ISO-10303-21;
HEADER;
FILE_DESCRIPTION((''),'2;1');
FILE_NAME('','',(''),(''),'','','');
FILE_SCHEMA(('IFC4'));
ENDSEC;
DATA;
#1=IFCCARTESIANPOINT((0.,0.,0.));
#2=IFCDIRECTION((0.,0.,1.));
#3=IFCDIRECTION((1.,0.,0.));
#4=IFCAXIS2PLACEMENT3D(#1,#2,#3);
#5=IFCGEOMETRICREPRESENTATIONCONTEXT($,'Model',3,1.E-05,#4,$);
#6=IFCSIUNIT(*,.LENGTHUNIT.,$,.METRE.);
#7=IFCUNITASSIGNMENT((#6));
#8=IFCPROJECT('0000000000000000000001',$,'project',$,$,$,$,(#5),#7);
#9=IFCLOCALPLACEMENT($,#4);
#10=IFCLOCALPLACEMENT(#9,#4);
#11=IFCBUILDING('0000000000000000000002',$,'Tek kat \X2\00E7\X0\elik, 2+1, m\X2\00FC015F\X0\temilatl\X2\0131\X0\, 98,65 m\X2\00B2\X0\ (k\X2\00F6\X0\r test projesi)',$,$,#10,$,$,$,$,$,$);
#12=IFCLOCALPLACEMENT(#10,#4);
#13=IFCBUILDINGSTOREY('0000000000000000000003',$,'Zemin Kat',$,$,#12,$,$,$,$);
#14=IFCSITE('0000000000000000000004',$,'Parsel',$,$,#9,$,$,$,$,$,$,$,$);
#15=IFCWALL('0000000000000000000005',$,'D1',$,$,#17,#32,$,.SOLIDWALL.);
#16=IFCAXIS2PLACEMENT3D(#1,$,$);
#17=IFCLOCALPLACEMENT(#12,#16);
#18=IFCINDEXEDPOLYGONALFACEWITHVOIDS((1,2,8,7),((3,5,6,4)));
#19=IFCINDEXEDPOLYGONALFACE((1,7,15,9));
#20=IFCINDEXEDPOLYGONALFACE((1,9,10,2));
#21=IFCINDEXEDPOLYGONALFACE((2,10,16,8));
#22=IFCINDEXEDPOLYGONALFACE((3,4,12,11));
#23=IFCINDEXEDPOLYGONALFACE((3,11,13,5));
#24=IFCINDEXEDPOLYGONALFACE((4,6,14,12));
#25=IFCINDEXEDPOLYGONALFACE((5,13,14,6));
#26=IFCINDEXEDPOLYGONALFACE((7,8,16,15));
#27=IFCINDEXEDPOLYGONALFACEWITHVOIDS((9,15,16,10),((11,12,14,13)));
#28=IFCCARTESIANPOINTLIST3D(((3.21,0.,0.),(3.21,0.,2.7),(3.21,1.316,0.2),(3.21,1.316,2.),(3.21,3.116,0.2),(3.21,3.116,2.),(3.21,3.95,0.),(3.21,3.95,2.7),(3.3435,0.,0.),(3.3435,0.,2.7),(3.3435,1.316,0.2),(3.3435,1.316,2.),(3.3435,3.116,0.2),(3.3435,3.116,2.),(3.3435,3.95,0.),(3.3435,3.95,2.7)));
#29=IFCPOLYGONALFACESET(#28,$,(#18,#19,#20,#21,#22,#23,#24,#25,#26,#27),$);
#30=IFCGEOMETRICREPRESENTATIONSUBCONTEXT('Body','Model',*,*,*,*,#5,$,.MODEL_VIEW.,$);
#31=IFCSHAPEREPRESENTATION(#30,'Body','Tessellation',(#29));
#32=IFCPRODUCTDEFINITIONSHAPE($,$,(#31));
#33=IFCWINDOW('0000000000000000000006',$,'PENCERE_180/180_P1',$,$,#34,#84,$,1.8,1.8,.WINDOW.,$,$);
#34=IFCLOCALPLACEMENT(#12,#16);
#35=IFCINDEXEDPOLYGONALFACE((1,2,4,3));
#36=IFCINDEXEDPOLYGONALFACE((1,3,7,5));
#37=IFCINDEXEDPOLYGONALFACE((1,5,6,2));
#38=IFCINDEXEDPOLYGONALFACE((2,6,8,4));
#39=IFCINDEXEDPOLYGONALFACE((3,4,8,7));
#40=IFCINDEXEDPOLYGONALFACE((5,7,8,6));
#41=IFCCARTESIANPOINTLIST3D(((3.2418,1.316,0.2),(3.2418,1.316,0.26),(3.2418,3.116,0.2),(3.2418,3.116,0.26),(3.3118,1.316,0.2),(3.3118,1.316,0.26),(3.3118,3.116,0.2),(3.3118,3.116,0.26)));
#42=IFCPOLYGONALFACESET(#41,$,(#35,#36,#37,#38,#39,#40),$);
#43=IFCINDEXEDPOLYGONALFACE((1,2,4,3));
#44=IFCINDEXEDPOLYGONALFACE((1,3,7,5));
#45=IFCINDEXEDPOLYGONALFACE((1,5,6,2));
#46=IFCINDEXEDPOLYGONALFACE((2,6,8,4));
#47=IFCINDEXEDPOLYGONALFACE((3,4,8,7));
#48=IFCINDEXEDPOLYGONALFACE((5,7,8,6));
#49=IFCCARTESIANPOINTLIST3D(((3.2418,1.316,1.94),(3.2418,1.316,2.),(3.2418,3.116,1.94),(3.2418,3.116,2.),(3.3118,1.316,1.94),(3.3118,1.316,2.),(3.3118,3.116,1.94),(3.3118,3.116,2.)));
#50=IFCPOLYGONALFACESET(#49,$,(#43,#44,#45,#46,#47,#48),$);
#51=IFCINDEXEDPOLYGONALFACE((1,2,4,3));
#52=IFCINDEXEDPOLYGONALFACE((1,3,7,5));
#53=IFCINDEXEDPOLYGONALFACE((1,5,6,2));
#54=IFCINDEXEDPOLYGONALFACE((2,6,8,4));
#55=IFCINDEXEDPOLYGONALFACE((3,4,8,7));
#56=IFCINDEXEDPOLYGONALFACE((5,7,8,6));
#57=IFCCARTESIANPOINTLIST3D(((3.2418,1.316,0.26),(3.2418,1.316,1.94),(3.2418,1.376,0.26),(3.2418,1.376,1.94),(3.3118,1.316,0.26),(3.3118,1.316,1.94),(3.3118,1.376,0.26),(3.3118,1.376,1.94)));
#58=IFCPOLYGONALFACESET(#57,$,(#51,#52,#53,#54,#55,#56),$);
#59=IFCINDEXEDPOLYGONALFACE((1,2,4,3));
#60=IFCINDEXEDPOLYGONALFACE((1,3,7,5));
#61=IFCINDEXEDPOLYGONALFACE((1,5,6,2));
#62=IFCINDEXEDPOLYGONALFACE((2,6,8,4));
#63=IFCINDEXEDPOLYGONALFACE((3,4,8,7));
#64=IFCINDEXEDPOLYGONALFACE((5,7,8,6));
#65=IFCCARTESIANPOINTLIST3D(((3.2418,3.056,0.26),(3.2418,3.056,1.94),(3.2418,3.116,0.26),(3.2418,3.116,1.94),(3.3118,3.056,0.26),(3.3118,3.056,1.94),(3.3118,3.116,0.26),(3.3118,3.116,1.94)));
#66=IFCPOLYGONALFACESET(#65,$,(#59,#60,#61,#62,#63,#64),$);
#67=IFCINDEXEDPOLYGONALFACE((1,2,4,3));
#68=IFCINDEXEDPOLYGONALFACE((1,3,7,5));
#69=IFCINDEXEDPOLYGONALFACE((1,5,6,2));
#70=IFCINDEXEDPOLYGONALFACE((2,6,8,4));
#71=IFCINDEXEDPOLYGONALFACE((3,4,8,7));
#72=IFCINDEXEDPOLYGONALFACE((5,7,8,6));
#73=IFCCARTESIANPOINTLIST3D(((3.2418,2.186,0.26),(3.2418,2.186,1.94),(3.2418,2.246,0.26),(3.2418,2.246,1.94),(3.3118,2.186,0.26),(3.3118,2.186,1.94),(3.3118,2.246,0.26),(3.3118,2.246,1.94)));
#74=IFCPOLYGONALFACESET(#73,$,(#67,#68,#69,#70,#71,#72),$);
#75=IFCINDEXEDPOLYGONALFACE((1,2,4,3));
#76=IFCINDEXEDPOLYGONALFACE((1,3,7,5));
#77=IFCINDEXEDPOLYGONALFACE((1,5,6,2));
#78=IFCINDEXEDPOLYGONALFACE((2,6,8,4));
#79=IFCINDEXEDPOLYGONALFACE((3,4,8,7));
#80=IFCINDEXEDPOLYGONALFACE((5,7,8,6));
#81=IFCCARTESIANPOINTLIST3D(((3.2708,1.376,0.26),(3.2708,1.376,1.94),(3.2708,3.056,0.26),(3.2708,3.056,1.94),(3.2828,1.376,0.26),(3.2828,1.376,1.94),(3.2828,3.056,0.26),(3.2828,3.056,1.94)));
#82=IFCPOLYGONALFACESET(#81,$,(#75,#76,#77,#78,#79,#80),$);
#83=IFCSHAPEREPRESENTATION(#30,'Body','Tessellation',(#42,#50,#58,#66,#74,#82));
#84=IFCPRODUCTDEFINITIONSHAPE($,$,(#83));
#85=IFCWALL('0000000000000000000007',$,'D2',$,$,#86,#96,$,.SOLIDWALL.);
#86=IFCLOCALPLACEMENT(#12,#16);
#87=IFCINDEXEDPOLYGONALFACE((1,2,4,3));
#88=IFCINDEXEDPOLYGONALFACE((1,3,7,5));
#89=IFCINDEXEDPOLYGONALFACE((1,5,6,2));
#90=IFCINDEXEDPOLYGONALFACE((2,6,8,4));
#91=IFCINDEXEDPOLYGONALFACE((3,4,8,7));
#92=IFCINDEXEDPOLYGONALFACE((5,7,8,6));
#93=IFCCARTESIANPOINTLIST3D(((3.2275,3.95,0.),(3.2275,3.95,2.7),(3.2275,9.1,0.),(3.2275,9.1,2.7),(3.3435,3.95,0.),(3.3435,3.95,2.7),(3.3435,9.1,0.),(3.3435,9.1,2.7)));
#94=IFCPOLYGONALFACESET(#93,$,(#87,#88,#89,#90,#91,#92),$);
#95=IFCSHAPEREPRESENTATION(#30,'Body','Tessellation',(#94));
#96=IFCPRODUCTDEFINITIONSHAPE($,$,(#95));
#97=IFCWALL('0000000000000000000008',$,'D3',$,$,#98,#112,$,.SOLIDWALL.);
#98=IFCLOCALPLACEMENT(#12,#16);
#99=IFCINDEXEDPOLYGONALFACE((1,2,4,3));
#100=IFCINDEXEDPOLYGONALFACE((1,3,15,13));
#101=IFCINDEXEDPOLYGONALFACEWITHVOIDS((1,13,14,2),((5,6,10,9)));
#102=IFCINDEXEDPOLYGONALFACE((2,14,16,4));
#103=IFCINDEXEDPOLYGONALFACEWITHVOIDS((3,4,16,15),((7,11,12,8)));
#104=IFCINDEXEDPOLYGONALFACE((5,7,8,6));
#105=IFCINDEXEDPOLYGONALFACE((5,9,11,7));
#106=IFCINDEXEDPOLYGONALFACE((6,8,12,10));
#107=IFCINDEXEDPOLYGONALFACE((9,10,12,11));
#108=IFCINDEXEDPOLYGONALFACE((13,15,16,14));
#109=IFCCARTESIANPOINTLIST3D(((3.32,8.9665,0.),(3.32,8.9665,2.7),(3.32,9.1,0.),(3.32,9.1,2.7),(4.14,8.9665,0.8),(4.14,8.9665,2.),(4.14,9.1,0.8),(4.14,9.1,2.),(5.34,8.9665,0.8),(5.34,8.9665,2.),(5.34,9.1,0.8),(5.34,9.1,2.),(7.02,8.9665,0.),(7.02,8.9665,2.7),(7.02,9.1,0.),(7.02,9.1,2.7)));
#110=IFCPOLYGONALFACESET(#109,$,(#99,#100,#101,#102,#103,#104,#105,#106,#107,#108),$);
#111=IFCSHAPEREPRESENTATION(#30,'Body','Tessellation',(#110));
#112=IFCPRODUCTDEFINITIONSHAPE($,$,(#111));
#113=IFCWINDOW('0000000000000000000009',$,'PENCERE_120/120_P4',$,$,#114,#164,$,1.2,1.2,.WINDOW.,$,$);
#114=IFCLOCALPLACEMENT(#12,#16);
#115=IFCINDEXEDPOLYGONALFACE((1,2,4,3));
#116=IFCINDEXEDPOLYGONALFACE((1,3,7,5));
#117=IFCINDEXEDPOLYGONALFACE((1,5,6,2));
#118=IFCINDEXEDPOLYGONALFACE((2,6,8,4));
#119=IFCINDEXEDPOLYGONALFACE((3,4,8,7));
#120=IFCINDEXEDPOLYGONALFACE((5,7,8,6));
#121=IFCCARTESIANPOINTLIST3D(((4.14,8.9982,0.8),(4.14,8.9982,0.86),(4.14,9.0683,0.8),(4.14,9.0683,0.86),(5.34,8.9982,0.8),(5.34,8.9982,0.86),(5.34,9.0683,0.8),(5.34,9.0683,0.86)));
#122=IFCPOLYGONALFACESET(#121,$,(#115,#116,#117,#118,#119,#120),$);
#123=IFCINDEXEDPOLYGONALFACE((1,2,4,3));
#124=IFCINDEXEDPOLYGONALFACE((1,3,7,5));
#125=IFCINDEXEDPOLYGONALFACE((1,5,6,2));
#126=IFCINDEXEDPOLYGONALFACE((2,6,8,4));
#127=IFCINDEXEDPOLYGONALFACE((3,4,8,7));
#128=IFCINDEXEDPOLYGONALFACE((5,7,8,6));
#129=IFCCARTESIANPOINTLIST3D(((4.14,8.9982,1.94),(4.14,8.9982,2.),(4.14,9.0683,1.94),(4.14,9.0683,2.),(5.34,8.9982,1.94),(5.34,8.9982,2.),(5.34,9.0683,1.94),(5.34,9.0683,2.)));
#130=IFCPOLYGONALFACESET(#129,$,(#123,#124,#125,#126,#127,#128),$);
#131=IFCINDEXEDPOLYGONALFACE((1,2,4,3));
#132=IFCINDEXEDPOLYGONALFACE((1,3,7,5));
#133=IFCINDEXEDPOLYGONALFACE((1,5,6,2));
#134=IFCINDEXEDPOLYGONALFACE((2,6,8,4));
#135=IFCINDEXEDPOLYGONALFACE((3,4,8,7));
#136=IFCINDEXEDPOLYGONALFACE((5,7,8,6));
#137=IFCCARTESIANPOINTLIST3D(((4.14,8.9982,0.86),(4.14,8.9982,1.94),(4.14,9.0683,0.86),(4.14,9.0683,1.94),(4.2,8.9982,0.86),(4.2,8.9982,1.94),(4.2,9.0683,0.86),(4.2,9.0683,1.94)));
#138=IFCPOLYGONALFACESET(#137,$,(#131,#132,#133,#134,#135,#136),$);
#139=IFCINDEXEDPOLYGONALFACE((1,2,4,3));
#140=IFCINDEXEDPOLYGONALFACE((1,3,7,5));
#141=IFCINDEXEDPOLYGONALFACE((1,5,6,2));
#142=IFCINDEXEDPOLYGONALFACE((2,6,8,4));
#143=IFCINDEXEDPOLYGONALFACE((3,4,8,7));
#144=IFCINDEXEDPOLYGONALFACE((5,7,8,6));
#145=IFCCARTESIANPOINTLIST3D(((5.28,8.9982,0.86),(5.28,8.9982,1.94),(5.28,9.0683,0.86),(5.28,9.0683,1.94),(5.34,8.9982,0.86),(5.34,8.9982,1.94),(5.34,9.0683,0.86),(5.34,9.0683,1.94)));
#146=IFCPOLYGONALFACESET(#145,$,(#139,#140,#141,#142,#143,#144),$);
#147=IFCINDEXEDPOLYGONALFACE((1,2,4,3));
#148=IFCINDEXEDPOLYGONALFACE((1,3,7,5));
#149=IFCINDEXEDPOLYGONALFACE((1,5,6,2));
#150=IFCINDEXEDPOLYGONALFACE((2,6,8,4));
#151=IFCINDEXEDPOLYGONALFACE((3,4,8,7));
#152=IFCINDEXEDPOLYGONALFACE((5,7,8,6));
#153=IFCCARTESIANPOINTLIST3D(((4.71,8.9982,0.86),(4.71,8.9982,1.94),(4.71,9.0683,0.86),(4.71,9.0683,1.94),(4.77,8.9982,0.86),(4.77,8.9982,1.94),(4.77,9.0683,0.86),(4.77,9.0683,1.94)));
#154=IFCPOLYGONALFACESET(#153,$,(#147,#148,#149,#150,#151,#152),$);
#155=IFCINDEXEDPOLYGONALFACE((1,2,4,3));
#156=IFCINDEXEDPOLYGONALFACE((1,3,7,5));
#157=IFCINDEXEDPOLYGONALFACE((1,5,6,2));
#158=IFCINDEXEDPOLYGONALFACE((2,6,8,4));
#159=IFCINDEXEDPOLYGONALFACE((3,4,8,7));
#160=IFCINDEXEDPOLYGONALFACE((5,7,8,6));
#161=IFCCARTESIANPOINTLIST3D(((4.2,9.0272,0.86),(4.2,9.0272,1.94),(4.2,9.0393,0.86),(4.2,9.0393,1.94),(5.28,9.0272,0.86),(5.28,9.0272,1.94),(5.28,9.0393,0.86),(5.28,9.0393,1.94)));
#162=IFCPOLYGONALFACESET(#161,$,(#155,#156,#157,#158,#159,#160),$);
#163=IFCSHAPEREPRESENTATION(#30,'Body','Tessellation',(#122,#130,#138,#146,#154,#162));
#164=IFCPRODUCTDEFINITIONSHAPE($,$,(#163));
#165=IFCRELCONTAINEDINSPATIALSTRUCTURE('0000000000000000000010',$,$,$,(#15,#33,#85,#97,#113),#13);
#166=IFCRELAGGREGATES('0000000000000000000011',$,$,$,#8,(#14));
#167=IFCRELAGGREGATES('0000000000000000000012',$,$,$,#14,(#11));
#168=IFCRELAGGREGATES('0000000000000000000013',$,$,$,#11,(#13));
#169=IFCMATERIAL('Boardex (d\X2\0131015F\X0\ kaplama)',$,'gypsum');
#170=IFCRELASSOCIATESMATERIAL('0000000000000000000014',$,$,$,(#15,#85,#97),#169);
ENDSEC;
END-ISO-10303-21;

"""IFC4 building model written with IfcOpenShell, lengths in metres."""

from ifc_helpers import new_model, si_unit, frame, origin_with_axes, place, context, subcontext, project, spatial, line, indexed_curve, outline, extrude, material, element, fill, save


model = new_model("IFC4")

# Units and contexts
model_context = context("Model", 3, precision=1e-05, world=origin_with_axes())
body_context = subcontext(model_context, "Body", "Model", "MODEL_VIEW")
ifc_project = project(units=[si_unit("LENGTHUNIT", "METRE")], contexts=[model_context])

# Site, building, storey
site_placement = place(None, origin_with_axes())
site = spatial("IfcSite", under=ifc_project, at=site_placement, Name="Parsel")
building_placement = place(site_placement, origin_with_axes())
building = spatial("IfcBuilding", under=site, at=building_placement, Name="Tek kat çelik, 2+1, müştemilatlı, 98,65 m² (kör test projesi)")
storey_placement = place(building_placement, origin_with_axes())
storey = spatial("IfcBuildingStorey", under=building, at=storey_placement, Name="Zemin Kat")

# Wall, opening, window
ifc_material_1 = material(Name="Boardex (dış kaplama)", Category="gypsum")
wall_1_placement = place(storey_placement, origin_with_axes())
wall_1 = element("IfcWall", 1, at=wall_1_placement, inside=storey, material=ifc_material_1, Name="D1", PredefinedType="SOLIDWALL", context=body_context, shape_type="SweptSolid", body=[
    extrude(outline(indexed_curve([(0.0, 0.0), (0.1335, 0.0), (0.1335, 3.95), (0.0, 3.95)], segments=[line(1, 2, 3, 4, 1)])), frame((3.21, 0.0, 0.0), z_axis=(0.0, 0.0, 1.0), x_axis=(1.0, 0.0, 0.0)), (0.0, 0.0, 1.0), 2.7),
])
opening_1_placement = place(wall_1_placement, origin_with_axes())
opening_1 = element("IfcOpeningElement", 2, at=opening_1_placement, cuts=wall_1, PredefinedType="OPENING", context=body_context, shape_type="SweptSolid", body=[
    extrude(outline(indexed_curve([(0.0, 0.0), (0.1735, 0.0), (0.1735, 1.8), (0.0, 1.8)], segments=[line(1, 2, 3, 4, 1)])), frame((3.19, 1.316, 0.2), z_axis=(0.0, 0.0, 1.0), x_axis=(1.0, 0.0, 0.0)), (0.0, 0.0, 1.0), 1.8),
])
window_1_placement = place(storey_placement, origin_with_axes())
window_1 = element("IfcWindow", 3, at=window_1_placement, inside=storey, Name="PENCERE_180/180_P1", OverallHeight=1.8, OverallWidth=1.8, PredefinedType="WINDOW", context=body_context, shape_type="SweptSolid", body=[
    extrude(outline(indexed_curve([(0.0, 0.0), (0.07, 0.0), (0.07, 1.8), (0.0, 1.8)], segments=[line(1, 2, 3, 4, 1)])), frame((3.2418, 1.316, 0.2), z_axis=(0.0, 0.0, 1.0), x_axis=(1.0, 0.0, 0.0)), (0.0, 0.0, 1.0), 0.06),
    extrude(outline(indexed_curve([(0.0, 0.0), (0.07, 0.0), (0.07, 1.8), (0.0, 1.8)], segments=[line(1, 2, 3, 4, 1)])), frame((3.2418, 1.316, 1.94), z_axis=(0.0, 0.0, 1.0), x_axis=(1.0, 0.0, 0.0)), (0.0, 0.0, 1.0), 0.06),
    extrude(outline(indexed_curve([(0.0, 0.0), (0.07, 0.0), (0.07, 0.06), (0.0, 0.06)], segments=[line(1, 2, 3, 4, 1)])), frame((3.2418, 1.316, 0.26), z_axis=(0.0, 0.0, 1.0), x_axis=(1.0, 0.0, 0.0)), (0.0, 0.0, 1.0), 1.68),
    extrude(outline(indexed_curve([(0.0, 0.0), (0.07, 0.0), (0.07, 0.06), (0.0, 0.06)], segments=[line(1, 2, 3, 4, 1)])), frame((3.2418, 3.056, 0.26), z_axis=(0.0, 0.0, 1.0), x_axis=(1.0, 0.0, 0.0)), (0.0, 0.0, 1.0), 1.68),
    extrude(outline(indexed_curve([(0.0, 0.0), (0.07, 0.0), (0.07, 0.06), (0.0, 0.06)], segments=[line(1, 2, 3, 4, 1)])), frame((3.2418, 2.186, 0.26), z_axis=(0.0, 0.0, 1.0), x_axis=(1.0, 0.0, 0.0)), (0.0, 0.0, 1.0), 1.68),
    extrude(outline(indexed_curve([(0.0, 0.0), (0.012, 0.0), (0.012, 1.68), (0.0, 1.68)], segments=[line(1, 2, 3, 4, 1)])), frame((3.2708, 1.376, 0.26), z_axis=(0.0, 0.0, 1.0), x_axis=(1.0, 0.0, 0.0)), (0.0, 0.0, 1.0), 1.68),
])
fill(opening_1, window_1)

# Wall
wall_2_placement = place(storey_placement, origin_with_axes())
element("IfcWall", 4, at=wall_2_placement, inside=storey, material=ifc_material_1, Name="D2", PredefinedType="SOLIDWALL", context=body_context, shape_type="SweptSolid", body=[
    extrude(outline(indexed_curve([(0.0, 0.0), (0.116, 0.0), (0.116, 5.15), (0.0, 5.15)], segments=[line(1, 2, 3, 4, 1)])), frame((3.2275, 3.95, 0.0), z_axis=(0.0, 0.0, 1.0), x_axis=(1.0, 0.0, 0.0)), (0.0, 0.0, 1.0), 2.7),
])

# Wall, opening, window
wall_3_placement = place(storey_placement, origin_with_axes())
wall_3 = element("IfcWall", 5, at=wall_3_placement, inside=storey, material=ifc_material_1, Name="D3", PredefinedType="SOLIDWALL", context=body_context, shape_type="SweptSolid", body=[
    extrude(outline(indexed_curve([(0.0, 0.0), (3.7, 0.0), (3.7, 0.1335), (0.0, 0.1335)], segments=[line(1, 2, 3, 4, 1)])), frame((3.32, 8.9665, 0.0), z_axis=(0.0, 0.0, 1.0), x_axis=(1.0, 0.0, 0.0)), (0.0, 0.0, 1.0), 2.7),
])
opening_2_placement = place(wall_3_placement, origin_with_axes())
opening_2 = element("IfcOpeningElement", 6, at=opening_2_placement, cuts=wall_3, PredefinedType="OPENING", context=body_context, shape_type="SweptSolid", body=[
    extrude(outline(indexed_curve([(0.0, 0.0), (1.2, 0.0), (1.2, 0.1735), (0.0, 0.1735)], segments=[line(1, 2, 3, 4, 1)])), frame((4.14, 8.9465, 0.8), z_axis=(0.0, 0.0, 1.0), x_axis=(1.0, 0.0, 0.0)), (0.0, 0.0, 1.0), 1.2),
])
window_2_placement = place(storey_placement, origin_with_axes())
window_2 = element("IfcWindow", 7, at=window_2_placement, inside=storey, Name="PENCERE_120/120_P4", OverallHeight=1.2, OverallWidth=1.2, PredefinedType="WINDOW", context=body_context, shape_type="SweptSolid", body=[
    extrude(outline(indexed_curve([(0.0, 0.0), (1.2, 0.0), (1.2, 0.07), (0.0, 0.07)], segments=[line(1, 2, 3, 4, 1)])), frame((4.14, 8.9983, 0.8), z_axis=(0.0, 0.0, 1.0), x_axis=(1.0, 0.0, 0.0)), (0.0, 0.0, 1.0), 0.06),
    extrude(outline(indexed_curve([(0.0, 0.0), (1.2, 0.0), (1.2, 0.07), (0.0, 0.07)], segments=[line(1, 2, 3, 4, 1)])), frame((4.14, 8.9983, 1.94), z_axis=(0.0, 0.0, 1.0), x_axis=(1.0, 0.0, 0.0)), (0.0, 0.0, 1.0), 0.06),
    extrude(outline(indexed_curve([(0.0, 0.0), (0.06, 0.0), (0.06, 0.07), (0.0, 0.07)], segments=[line(1, 2, 3, 4, 1)])), frame((4.14, 8.9983, 0.86), z_axis=(0.0, 0.0, 1.0), x_axis=(1.0, 0.0, 0.0)), (0.0, 0.0, 1.0), 1.08),
    extrude(outline(indexed_curve([(0.0, 0.0), (0.06, 0.0), (0.06, 0.07), (0.0, 0.07)], segments=[line(1, 2, 3, 4, 1)])), frame((5.28, 8.9983, 0.86), z_axis=(0.0, 0.0, 1.0), x_axis=(1.0, 0.0, 0.0)), (0.0, 0.0, 1.0), 1.08),
    extrude(outline(indexed_curve([(0.0, 0.0), (0.06, 0.0), (0.06, 0.07), (0.0, 0.07)], segments=[line(1, 2, 3, 4, 1)])), frame((4.71, 8.9983, 0.86), z_axis=(0.0, 0.0, 1.0), x_axis=(1.0, 0.0, 0.0)), (0.0, 0.0, 1.0), 1.08),
    extrude(outline(indexed_curve([(0.0, 0.0), (1.08, 0.0), (1.08, 0.012), (0.0, 0.012)], segments=[line(1, 2, 3, 4, 1)])), frame((4.2, 9.0273, 0.86), z_axis=(0.0, 0.0, 1.0), x_axis=(1.0, 0.0, 0.0)), (0.0, 0.0, 1.0), 1.08),
])
fill(opening_2, window_2)

save(model, "model.ifc")
